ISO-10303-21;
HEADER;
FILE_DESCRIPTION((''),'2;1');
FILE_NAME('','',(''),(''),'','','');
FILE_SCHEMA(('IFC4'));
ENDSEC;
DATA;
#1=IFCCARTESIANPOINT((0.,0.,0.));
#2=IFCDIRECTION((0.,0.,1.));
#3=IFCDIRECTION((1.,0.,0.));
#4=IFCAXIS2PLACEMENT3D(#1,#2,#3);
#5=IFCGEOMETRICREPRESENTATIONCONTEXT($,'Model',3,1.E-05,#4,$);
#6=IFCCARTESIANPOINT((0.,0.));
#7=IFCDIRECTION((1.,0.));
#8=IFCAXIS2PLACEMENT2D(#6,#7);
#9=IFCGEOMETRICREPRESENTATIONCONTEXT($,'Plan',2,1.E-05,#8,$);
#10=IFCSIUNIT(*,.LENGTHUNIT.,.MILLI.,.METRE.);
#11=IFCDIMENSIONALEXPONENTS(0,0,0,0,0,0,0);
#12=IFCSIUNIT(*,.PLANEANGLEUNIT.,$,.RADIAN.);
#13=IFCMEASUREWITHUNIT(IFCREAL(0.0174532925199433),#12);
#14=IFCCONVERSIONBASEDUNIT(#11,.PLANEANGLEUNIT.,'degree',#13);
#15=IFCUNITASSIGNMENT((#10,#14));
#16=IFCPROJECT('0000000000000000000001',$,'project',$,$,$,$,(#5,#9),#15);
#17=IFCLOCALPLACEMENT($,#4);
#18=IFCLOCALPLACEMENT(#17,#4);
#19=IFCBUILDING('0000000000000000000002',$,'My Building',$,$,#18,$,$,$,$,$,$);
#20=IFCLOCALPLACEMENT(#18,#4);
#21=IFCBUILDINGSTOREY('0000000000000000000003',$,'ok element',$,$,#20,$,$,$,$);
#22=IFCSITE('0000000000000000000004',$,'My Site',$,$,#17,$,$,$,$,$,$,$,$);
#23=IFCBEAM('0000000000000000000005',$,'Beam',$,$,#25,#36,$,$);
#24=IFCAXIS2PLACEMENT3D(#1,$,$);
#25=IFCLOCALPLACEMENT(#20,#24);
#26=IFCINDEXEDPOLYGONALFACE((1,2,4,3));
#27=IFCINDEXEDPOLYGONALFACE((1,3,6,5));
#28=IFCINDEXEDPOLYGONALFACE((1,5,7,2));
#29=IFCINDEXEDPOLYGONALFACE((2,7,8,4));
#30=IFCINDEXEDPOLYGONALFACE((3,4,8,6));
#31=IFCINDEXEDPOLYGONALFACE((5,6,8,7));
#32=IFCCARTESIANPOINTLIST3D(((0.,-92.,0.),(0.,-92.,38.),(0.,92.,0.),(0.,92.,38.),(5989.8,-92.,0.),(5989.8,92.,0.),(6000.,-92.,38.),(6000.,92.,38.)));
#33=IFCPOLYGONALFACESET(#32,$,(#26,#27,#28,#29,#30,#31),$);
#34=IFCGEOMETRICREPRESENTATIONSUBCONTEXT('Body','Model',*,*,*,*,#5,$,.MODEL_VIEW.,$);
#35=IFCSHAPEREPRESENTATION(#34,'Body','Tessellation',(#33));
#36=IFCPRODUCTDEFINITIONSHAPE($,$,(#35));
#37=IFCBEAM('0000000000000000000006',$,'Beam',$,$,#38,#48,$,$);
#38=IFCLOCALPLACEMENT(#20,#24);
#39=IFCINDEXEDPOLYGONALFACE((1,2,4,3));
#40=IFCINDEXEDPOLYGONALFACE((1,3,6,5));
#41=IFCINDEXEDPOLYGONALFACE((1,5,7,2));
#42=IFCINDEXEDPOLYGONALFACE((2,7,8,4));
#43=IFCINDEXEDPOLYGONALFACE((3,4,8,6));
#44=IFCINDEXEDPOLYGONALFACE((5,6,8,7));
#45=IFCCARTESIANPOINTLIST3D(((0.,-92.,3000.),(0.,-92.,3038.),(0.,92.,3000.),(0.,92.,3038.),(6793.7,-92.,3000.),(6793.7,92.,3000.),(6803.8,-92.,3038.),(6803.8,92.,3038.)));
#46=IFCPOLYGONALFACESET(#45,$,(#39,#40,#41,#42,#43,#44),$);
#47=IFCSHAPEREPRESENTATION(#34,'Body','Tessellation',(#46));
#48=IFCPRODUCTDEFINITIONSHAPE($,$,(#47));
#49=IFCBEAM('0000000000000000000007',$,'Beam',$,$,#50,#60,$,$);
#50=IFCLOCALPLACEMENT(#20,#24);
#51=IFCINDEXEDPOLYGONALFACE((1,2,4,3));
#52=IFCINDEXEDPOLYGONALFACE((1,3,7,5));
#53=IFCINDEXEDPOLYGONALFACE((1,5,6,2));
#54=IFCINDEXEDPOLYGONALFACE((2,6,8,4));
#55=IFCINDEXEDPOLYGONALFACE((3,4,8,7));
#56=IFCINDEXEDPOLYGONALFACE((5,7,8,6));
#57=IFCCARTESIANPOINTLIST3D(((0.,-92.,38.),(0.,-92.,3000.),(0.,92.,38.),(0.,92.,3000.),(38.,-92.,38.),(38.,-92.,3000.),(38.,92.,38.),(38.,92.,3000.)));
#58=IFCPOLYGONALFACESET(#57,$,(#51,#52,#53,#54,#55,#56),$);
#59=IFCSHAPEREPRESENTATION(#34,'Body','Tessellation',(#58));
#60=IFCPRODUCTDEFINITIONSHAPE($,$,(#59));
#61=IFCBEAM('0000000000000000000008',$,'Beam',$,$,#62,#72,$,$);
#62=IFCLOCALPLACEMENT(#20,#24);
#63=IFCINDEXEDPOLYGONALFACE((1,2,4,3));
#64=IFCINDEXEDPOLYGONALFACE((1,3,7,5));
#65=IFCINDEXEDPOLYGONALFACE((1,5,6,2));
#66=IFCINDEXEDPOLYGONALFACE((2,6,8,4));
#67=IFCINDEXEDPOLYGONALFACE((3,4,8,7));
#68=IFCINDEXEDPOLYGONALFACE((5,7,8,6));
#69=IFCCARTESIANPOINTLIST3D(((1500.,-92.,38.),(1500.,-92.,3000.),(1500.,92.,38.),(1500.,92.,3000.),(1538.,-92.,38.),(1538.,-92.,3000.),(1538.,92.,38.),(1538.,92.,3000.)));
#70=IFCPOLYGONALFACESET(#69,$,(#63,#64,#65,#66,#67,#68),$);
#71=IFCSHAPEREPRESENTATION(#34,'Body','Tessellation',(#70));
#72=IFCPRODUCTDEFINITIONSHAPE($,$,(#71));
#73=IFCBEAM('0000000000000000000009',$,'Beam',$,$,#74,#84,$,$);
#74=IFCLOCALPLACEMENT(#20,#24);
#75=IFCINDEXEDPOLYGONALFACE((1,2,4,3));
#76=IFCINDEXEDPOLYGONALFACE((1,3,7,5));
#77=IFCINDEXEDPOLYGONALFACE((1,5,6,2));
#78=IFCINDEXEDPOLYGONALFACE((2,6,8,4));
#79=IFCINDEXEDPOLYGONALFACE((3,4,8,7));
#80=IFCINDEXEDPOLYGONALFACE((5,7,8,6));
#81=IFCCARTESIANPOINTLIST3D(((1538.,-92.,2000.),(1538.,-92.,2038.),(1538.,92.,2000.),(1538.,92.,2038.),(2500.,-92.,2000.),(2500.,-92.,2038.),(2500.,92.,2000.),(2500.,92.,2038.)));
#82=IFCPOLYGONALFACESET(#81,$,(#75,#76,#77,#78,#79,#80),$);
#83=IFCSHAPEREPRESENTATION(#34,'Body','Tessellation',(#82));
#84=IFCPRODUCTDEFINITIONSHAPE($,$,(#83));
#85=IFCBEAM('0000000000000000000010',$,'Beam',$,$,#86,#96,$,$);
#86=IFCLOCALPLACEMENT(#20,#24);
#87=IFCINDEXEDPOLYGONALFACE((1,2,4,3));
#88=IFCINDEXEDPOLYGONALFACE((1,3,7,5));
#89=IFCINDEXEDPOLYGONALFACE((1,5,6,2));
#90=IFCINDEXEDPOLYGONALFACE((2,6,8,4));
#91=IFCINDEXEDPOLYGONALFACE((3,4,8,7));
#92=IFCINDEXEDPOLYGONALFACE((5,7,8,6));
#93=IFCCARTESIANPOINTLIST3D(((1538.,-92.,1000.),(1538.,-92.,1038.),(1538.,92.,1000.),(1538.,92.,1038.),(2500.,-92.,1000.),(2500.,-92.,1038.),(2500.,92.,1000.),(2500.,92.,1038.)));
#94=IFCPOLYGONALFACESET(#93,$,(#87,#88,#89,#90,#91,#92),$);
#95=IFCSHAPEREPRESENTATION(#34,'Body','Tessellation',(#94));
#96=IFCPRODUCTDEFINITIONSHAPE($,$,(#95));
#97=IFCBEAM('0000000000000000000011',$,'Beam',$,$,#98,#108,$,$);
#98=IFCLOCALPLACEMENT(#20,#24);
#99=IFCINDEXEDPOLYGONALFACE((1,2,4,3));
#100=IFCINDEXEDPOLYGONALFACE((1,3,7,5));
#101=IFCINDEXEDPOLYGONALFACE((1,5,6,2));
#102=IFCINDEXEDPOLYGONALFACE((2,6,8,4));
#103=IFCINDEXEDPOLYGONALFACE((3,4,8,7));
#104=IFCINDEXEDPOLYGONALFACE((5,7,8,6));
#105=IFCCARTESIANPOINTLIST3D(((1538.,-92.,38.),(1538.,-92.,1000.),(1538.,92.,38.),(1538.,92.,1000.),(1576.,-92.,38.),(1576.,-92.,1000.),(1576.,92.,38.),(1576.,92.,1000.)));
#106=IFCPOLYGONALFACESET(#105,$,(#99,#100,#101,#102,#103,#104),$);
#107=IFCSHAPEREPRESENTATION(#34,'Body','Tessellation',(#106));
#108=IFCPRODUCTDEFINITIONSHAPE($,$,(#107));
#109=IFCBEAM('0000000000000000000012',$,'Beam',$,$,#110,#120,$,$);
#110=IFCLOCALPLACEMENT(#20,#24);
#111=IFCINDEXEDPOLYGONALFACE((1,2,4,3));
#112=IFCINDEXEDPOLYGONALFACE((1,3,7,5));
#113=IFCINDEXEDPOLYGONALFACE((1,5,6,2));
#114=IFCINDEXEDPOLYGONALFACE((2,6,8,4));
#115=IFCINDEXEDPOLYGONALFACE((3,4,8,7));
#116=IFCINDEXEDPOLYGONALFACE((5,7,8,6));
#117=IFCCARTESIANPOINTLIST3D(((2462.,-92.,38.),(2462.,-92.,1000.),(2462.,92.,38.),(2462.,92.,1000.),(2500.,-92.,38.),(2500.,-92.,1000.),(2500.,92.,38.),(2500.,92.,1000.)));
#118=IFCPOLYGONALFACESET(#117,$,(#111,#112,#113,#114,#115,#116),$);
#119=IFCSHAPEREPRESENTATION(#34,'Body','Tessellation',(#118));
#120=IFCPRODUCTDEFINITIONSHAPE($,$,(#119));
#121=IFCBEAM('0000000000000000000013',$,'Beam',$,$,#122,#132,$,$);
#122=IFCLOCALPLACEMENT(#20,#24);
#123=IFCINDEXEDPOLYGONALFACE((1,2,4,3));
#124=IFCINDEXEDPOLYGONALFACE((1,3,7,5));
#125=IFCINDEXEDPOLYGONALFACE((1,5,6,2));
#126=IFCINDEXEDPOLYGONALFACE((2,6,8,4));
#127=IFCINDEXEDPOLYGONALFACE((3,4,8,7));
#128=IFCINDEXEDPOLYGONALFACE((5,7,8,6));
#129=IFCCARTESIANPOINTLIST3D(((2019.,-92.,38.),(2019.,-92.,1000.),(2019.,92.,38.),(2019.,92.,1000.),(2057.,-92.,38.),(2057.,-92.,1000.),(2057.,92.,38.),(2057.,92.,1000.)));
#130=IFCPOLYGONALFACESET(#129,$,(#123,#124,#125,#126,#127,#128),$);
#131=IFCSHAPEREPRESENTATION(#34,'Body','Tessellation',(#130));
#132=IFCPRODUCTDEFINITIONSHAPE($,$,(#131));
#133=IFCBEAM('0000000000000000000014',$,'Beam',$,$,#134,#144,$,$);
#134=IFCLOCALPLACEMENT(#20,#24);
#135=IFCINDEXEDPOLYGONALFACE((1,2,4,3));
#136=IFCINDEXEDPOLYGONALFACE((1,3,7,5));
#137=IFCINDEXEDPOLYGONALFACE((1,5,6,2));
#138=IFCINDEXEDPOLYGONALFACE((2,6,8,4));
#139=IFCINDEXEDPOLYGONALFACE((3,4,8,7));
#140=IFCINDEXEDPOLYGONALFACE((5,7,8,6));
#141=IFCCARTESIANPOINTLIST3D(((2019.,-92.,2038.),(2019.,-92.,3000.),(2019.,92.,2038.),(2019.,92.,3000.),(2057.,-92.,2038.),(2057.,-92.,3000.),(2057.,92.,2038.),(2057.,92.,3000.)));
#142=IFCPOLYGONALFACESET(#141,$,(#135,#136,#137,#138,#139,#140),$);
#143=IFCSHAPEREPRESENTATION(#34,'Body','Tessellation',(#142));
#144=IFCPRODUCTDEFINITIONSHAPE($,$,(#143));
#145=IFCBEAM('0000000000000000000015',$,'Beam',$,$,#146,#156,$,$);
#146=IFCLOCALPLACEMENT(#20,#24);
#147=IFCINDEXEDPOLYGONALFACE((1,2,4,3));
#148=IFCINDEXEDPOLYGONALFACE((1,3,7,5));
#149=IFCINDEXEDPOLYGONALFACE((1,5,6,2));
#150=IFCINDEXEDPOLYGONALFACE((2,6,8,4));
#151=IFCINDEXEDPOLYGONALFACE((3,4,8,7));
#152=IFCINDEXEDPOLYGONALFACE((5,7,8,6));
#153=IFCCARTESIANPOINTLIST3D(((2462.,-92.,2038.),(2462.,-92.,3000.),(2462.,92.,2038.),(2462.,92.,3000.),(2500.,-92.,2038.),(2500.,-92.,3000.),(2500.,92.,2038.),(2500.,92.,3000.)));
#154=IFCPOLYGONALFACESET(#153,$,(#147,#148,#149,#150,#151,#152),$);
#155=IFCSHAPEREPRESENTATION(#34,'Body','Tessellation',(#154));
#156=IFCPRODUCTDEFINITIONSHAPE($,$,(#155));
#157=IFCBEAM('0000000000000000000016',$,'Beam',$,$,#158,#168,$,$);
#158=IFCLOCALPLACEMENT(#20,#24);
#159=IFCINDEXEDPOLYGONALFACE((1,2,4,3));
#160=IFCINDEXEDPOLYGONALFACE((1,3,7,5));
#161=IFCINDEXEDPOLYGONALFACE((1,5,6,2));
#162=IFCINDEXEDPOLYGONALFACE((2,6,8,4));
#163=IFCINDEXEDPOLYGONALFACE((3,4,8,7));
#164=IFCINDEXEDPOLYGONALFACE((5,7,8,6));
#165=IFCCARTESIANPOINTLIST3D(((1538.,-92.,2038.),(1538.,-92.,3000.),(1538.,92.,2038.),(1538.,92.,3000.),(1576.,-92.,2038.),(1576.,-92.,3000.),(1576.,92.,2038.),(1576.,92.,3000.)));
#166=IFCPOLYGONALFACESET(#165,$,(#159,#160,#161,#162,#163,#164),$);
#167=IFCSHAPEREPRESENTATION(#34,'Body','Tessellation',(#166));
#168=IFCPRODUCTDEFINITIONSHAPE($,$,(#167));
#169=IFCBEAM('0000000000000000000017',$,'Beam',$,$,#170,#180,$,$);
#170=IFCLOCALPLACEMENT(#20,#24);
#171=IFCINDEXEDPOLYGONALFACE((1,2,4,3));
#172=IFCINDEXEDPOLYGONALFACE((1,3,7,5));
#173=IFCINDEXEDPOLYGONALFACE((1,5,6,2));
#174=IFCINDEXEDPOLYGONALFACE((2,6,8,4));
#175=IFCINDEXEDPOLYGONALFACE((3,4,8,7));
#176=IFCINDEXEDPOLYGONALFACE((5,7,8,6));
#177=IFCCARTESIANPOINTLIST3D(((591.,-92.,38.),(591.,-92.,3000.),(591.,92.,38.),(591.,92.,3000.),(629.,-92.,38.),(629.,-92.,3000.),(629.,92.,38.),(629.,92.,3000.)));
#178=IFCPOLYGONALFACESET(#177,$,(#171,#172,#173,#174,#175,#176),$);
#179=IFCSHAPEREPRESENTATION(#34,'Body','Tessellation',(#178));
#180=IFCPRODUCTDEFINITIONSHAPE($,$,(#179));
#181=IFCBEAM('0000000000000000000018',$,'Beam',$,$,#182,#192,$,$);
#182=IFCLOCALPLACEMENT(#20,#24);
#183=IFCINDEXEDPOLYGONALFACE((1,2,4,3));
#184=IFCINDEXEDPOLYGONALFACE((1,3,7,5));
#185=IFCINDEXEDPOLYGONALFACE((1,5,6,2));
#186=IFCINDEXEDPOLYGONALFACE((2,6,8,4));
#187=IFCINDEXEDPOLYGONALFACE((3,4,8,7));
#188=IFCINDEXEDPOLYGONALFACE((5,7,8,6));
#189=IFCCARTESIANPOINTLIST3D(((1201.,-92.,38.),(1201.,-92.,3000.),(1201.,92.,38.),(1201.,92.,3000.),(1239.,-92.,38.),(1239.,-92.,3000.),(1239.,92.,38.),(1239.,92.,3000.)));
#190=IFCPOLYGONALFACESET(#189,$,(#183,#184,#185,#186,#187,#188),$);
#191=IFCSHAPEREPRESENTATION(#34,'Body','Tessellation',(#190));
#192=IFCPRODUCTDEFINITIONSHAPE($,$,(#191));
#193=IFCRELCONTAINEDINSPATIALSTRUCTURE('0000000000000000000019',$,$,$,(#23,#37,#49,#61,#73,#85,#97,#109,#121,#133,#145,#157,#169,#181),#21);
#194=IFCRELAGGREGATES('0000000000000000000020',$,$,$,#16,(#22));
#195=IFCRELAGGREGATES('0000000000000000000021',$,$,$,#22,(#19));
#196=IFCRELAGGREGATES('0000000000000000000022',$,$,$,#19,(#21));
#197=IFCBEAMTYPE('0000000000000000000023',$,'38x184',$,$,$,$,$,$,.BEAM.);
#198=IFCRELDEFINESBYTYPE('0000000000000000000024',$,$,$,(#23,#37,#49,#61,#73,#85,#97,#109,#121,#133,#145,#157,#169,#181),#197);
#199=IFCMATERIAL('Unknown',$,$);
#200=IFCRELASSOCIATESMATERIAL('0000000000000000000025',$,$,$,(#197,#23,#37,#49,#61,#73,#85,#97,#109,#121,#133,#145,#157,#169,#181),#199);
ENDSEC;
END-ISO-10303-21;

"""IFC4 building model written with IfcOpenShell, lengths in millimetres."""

from ifc_helpers import new_model, entity, si_unit, converted_unit, frame, origin_with_axes, origin_2d_with_axis, place, context, subcontext, project, spatial, rectangle, extrude, clip, halfspace, material, material_profile, profile_set, profile_usage, type_object, element, save


model = new_model("IFC4")

# Units and contexts
model_context = context("Model", 3, precision=1e-05, world=origin_with_axes())
plan_context = context("Plan", 2, precision=1e-05, world=origin_2d_with_axis())
body_context = subcontext(model_context, "Body", "Model", "MODEL_VIEW")
ifc_project = project(units=[si_unit("LENGTHUNIT", "METRE", prefix="MILLI"), converted_unit("PLANEANGLEUNIT", "degree", entity("IfcReal", 0.0174532925199433), si_unit("PLANEANGLEUNIT", "RADIAN"), dimensions=[0, 0, 0, 0, 0, 0, 0])], contexts=[model_context, plan_context])

# Site, building, storey
site_placement = place(None, origin_with_axes())
site = spatial("IfcSite", under=ifc_project, at=site_placement, Name="My Site")
building_placement = place(site_placement, origin_with_axes())
building = spatial("IfcBuilding", under=site, at=building_placement, Name="My Building")
storey_placement = place(building_placement, origin_with_axes())
storey = spatial("IfcBuildingStorey", under=building, at=storey_placement, Name="ok element")

# Beams
ifc_material = material(Name="Unknown")
ifc_material_profile = material_profile(ifc_material, rectangle(XDim=184.0, YDim=38.0))
ifc_profile_set = profile_set([ifc_material_profile], Name="vurenhout")
ifc_profile_usage_1 = profile_usage(ifc_profile_set, cardinal=2)
beam_type = type_object("IfcBeamType", Name="38x184", PredefinedType="BEAM", material=ifc_profile_set)
beam_1_placement = place(storey_placement, frame((0.0, 0.0, 0.0), z_axis=(1.0, 0.0, 0.0), x_axis=(0.0, 1.0, 0.0)))
element("IfcBeam", 1, at=beam_1_placement, inside=storey, type_object=beam_type, material=ifc_profile_usage_1, Name="Beam", context=body_context, shape_type="Clipping", body=[
    clip(extrude(rectangle(XDim=184.0, YDim=38.0), frame((0.0, 19.0, 0.0), z_axis=(0.0, 0.0, 1.0), x_axis=(1.0, 0.0, 0.0)), (0.0, 0.0, 1.0), 6173.8), halfspace(frame((0.0, -177.7, 5942.2), z_axis=(0.0, -0.258819, 0.965926), x_axis=(0.0, 0.965926, 0.258819)), False)),
])
ifc_profile_usage_2 = profile_usage(ifc_profile_set, cardinal=2)
beam_2_placement = place(storey_placement, frame((0.0, 0.0, 3000.0), z_axis=(1.0, 0.0, 0.0), x_axis=(0.0, 1.0, 0.0)))
element("IfcBeam", 2, at=beam_2_placement, inside=storey, type_object=beam_type, material=ifc_profile_usage_2, Name="Beam", context=body_context, shape_type="Clipping", body=[
    clip(extrude(rectangle(XDim=184.0, YDim=38.0), frame((0.0, 19.0, 0.0), z_axis=(0.0, 0.0, 1.0), x_axis=(1.0, 0.0, 0.0)), (0.0, 0.0, 1.0), 6977.7), halfspace(frame((0.0, -3139.7, 5952.4), z_axis=(0.0, -0.258819, 0.965926), x_axis=(0.0, 0.965926, 0.258819)), False)),
])
ifc_profile_usage_3 = profile_usage(ifc_profile_set, cardinal=2)
beam_3_placement = place(storey_placement, frame((38.0, 0.0, 38.0), z_axis=(0.0, 0.0, 1.0), x_axis=(0.0, 1.0, 0.0)))
element("IfcBeam", 3, at=beam_3_placement, inside=storey, type_object=beam_type, material=ifc_profile_usage_3, Name="Beam", context=body_context, shape_type="SweptSolid", body=[
    extrude(rectangle(XDim=184.0, YDim=38.0), frame((0.0, 19.0, 0.0), z_axis=(0.0, 0.0, 1.0), x_axis=(1.0, 0.0, 0.0)), (0.0, 0.0, 1.0), 2962.0),
])
ifc_profile_usage_4 = profile_usage(ifc_profile_set, cardinal=2)
beam_4_placement = place(storey_placement, frame((1538.0, 0.0, 38.0), z_axis=(0.0, 0.0, 1.0), x_axis=(0.0, 1.0, 0.0)))
element("IfcBeam", 4, at=beam_4_placement, inside=storey, type_object=beam_type, material=ifc_profile_usage_4, Name="Beam", context=body_context, shape_type="SweptSolid", body=[
    extrude(rectangle(XDim=184.0, YDim=38.0), frame((0.0, 19.0, 0.0), z_axis=(0.0, 0.0, 1.0), x_axis=(1.0, 0.0, 0.0)), (0.0, 0.0, 1.0), 2962.0),
])
ifc_profile_usage_5 = profile_usage(ifc_profile_set, cardinal=2)
beam_5_placement = place(storey_placement, frame((1538.0, 0.0, 2000.0), z_axis=(1.0, 0.0, 0.0), x_axis=(0.0, 1.0, 0.0)))
element("IfcBeam", 5, at=beam_5_placement, inside=storey, type_object=beam_type, material=ifc_profile_usage_5, Name="Beam", context=body_context, shape_type="SweptSolid", body=[
    extrude(rectangle(XDim=184.0, YDim=38.0), frame((0.0, 19.0, 0.0), z_axis=(0.0, 0.0, 1.0), x_axis=(1.0, 0.0, 0.0)), (0.0, 0.0, 1.0), 962.0),
])
ifc_profile_usage_6 = profile_usage(ifc_profile_set, cardinal=2)
beam_6_placement = place(storey_placement, frame((1538.0, 0.0, 1000.0), z_axis=(1.0, 0.0, 0.0), x_axis=(0.0, 1.0, 0.0)))
element("IfcBeam", 6, at=beam_6_placement, inside=storey, type_object=beam_type, material=ifc_profile_usage_6, Name="Beam", context=body_context, shape_type="SweptSolid", body=[
    extrude(rectangle(XDim=184.0, YDim=38.0), frame((0.0, 19.0, 0.0), z_axis=(0.0, 0.0, 1.0), x_axis=(1.0, 0.0, 0.0)), (0.0, 0.0, 1.0), 962.0),
])
ifc_profile_usage_7 = profile_usage(ifc_profile_set, cardinal=2)
beam_7_placement = place(storey_placement, frame((1576.0, 0.0, 38.0), z_axis=(0.0, 0.0, 1.0), x_axis=(0.0, 1.0, 0.0)))
element("IfcBeam", 7, at=beam_7_placement, inside=storey, type_object=beam_type, material=ifc_profile_usage_7, Name="Beam", context=body_context, shape_type="SweptSolid", body=[
    extrude(rectangle(XDim=184.0, YDim=38.0), frame((0.0, 19.0, 0.0), z_axis=(0.0, 0.0, 1.0), x_axis=(1.0, 0.0, 0.0)), (0.0, 0.0, 1.0), 962.0),
])
ifc_profile_usage_8 = profile_usage(ifc_profile_set, cardinal=2)
beam_8_placement = place(storey_placement, frame((2500.0, 0.0, 38.0), z_axis=(0.0, 0.0, 1.0), x_axis=(0.0, 1.0, 0.0)))
element("IfcBeam", 8, at=beam_8_placement, inside=storey, type_object=beam_type, material=ifc_profile_usage_8, Name="Beam", context=body_context, shape_type="SweptSolid", body=[
    extrude(rectangle(XDim=184.0, YDim=38.0), frame((0.0, 19.0, 0.0), z_axis=(0.0, 0.0, 1.0), x_axis=(1.0, 0.0, 0.0)), (0.0, 0.0, 1.0), 962.0),
])
ifc_profile_usage_9 = profile_usage(ifc_profile_set, cardinal=2)
beam_9_placement = place(storey_placement, frame((2057.0, 0.0, 38.0), z_axis=(0.0, 0.0, 1.0), x_axis=(0.0, 1.0, 0.0)))
element("IfcBeam", 9, at=beam_9_placement, inside=storey, type_object=beam_type, material=ifc_profile_usage_9, Name="Beam", context=body_context, shape_type="SweptSolid", body=[
    extrude(rectangle(XDim=184.0, YDim=38.0), frame((0.0, 19.0, 0.0), z_axis=(0.0, 0.0, 1.0), x_axis=(1.0, 0.0, 0.0)), (0.0, 0.0, 1.0), 962.0),
])
ifc_profile_usage_10 = profile_usage(ifc_profile_set, cardinal=2)
beam_10_placement = place(storey_placement, frame((2057.0, 0.0, 2038.0), z_axis=(0.0, 0.0, 1.0), x_axis=(0.0, 1.0, 0.0)))
element("IfcBeam", 10, at=beam_10_placement, inside=storey, type_object=beam_type, material=ifc_profile_usage_10, Name="Beam", context=body_context, shape_type="SweptSolid", body=[
    extrude(rectangle(XDim=184.0, YDim=38.0), frame((0.0, 19.0, 0.0), z_axis=(0.0, 0.0, 1.0), x_axis=(1.0, 0.0, 0.0)), (0.0, 0.0, 1.0), 962.0),
])
ifc_profile_usage_11 = profile_usage(ifc_profile_set, cardinal=2)
beam_11_placement = place(storey_placement, frame((2500.0, 0.0, 2038.0), z_axis=(0.0, 0.0, 1.0), x_axis=(0.0, 1.0, 0.0)))
element("IfcBeam", 11, at=beam_11_placement, inside=storey, type_object=beam_type, material=ifc_profile_usage_11, Name="Beam", context=body_context, shape_type="SweptSolid", body=[
    extrude(rectangle(XDim=184.0, YDim=38.0), frame((0.0, 19.0, 0.0), z_axis=(0.0, 0.0, 1.0), x_axis=(1.0, 0.0, 0.0)), (0.0, 0.0, 1.0), 962.0),
])
ifc_profile_usage_12 = profile_usage(ifc_profile_set, cardinal=2)
beam_12_placement = place(storey_placement, frame((1576.0, 0.0, 2038.0), z_axis=(0.0, 0.0, 1.0), x_axis=(0.0, 1.0, 0.0)))
element("IfcBeam", 12, at=beam_12_placement, inside=storey, type_object=beam_type, material=ifc_profile_usage_12, Name="Beam", context=body_context, shape_type="SweptSolid", body=[
    extrude(rectangle(XDim=184.0, YDim=38.0), frame((0.0, 19.0, 0.0), z_axis=(0.0, 0.0, 1.0), x_axis=(1.0, 0.0, 0.0)), (0.0, 0.0, 1.0), 962.0),
])
ifc_profile_usage_13 = profile_usage(ifc_profile_set, cardinal=5)
beam_13_placement = place(storey_placement, frame((610.0, 0.0, 38.0), z_axis=(0.0, 0.0, 1.0), x_axis=(0.0, 1.0, 0.0)))
element("IfcBeam", 13, at=beam_13_placement, inside=storey, type_object=beam_type, material=ifc_profile_usage_13, Name="Beam", context=body_context, shape_type="SweptSolid", body=[
    extrude(rectangle(XDim=184.0, YDim=38.0), origin_with_axes(), (0.0, 0.0, 1.0), 2962.0),
])
ifc_profile_usage_14 = profile_usage(ifc_profile_set, cardinal=5)
beam_14_placement = place(storey_placement, frame((1220.0, 0.0, 38.0), z_axis=(0.0, 0.0, 1.0), x_axis=(0.0, 1.0, 0.0)))
element("IfcBeam", 14, at=beam_14_placement, inside=storey, type_object=beam_type, material=ifc_profile_usage_14, Name="Beam", context=body_context, shape_type="SweptSolid", body=[
    extrude(rectangle(XDim=184.0, YDim=38.0), origin_with_axes(), (0.0, 0.0, 1.0), 2962.0),
])

save(model, "model.ifc")
